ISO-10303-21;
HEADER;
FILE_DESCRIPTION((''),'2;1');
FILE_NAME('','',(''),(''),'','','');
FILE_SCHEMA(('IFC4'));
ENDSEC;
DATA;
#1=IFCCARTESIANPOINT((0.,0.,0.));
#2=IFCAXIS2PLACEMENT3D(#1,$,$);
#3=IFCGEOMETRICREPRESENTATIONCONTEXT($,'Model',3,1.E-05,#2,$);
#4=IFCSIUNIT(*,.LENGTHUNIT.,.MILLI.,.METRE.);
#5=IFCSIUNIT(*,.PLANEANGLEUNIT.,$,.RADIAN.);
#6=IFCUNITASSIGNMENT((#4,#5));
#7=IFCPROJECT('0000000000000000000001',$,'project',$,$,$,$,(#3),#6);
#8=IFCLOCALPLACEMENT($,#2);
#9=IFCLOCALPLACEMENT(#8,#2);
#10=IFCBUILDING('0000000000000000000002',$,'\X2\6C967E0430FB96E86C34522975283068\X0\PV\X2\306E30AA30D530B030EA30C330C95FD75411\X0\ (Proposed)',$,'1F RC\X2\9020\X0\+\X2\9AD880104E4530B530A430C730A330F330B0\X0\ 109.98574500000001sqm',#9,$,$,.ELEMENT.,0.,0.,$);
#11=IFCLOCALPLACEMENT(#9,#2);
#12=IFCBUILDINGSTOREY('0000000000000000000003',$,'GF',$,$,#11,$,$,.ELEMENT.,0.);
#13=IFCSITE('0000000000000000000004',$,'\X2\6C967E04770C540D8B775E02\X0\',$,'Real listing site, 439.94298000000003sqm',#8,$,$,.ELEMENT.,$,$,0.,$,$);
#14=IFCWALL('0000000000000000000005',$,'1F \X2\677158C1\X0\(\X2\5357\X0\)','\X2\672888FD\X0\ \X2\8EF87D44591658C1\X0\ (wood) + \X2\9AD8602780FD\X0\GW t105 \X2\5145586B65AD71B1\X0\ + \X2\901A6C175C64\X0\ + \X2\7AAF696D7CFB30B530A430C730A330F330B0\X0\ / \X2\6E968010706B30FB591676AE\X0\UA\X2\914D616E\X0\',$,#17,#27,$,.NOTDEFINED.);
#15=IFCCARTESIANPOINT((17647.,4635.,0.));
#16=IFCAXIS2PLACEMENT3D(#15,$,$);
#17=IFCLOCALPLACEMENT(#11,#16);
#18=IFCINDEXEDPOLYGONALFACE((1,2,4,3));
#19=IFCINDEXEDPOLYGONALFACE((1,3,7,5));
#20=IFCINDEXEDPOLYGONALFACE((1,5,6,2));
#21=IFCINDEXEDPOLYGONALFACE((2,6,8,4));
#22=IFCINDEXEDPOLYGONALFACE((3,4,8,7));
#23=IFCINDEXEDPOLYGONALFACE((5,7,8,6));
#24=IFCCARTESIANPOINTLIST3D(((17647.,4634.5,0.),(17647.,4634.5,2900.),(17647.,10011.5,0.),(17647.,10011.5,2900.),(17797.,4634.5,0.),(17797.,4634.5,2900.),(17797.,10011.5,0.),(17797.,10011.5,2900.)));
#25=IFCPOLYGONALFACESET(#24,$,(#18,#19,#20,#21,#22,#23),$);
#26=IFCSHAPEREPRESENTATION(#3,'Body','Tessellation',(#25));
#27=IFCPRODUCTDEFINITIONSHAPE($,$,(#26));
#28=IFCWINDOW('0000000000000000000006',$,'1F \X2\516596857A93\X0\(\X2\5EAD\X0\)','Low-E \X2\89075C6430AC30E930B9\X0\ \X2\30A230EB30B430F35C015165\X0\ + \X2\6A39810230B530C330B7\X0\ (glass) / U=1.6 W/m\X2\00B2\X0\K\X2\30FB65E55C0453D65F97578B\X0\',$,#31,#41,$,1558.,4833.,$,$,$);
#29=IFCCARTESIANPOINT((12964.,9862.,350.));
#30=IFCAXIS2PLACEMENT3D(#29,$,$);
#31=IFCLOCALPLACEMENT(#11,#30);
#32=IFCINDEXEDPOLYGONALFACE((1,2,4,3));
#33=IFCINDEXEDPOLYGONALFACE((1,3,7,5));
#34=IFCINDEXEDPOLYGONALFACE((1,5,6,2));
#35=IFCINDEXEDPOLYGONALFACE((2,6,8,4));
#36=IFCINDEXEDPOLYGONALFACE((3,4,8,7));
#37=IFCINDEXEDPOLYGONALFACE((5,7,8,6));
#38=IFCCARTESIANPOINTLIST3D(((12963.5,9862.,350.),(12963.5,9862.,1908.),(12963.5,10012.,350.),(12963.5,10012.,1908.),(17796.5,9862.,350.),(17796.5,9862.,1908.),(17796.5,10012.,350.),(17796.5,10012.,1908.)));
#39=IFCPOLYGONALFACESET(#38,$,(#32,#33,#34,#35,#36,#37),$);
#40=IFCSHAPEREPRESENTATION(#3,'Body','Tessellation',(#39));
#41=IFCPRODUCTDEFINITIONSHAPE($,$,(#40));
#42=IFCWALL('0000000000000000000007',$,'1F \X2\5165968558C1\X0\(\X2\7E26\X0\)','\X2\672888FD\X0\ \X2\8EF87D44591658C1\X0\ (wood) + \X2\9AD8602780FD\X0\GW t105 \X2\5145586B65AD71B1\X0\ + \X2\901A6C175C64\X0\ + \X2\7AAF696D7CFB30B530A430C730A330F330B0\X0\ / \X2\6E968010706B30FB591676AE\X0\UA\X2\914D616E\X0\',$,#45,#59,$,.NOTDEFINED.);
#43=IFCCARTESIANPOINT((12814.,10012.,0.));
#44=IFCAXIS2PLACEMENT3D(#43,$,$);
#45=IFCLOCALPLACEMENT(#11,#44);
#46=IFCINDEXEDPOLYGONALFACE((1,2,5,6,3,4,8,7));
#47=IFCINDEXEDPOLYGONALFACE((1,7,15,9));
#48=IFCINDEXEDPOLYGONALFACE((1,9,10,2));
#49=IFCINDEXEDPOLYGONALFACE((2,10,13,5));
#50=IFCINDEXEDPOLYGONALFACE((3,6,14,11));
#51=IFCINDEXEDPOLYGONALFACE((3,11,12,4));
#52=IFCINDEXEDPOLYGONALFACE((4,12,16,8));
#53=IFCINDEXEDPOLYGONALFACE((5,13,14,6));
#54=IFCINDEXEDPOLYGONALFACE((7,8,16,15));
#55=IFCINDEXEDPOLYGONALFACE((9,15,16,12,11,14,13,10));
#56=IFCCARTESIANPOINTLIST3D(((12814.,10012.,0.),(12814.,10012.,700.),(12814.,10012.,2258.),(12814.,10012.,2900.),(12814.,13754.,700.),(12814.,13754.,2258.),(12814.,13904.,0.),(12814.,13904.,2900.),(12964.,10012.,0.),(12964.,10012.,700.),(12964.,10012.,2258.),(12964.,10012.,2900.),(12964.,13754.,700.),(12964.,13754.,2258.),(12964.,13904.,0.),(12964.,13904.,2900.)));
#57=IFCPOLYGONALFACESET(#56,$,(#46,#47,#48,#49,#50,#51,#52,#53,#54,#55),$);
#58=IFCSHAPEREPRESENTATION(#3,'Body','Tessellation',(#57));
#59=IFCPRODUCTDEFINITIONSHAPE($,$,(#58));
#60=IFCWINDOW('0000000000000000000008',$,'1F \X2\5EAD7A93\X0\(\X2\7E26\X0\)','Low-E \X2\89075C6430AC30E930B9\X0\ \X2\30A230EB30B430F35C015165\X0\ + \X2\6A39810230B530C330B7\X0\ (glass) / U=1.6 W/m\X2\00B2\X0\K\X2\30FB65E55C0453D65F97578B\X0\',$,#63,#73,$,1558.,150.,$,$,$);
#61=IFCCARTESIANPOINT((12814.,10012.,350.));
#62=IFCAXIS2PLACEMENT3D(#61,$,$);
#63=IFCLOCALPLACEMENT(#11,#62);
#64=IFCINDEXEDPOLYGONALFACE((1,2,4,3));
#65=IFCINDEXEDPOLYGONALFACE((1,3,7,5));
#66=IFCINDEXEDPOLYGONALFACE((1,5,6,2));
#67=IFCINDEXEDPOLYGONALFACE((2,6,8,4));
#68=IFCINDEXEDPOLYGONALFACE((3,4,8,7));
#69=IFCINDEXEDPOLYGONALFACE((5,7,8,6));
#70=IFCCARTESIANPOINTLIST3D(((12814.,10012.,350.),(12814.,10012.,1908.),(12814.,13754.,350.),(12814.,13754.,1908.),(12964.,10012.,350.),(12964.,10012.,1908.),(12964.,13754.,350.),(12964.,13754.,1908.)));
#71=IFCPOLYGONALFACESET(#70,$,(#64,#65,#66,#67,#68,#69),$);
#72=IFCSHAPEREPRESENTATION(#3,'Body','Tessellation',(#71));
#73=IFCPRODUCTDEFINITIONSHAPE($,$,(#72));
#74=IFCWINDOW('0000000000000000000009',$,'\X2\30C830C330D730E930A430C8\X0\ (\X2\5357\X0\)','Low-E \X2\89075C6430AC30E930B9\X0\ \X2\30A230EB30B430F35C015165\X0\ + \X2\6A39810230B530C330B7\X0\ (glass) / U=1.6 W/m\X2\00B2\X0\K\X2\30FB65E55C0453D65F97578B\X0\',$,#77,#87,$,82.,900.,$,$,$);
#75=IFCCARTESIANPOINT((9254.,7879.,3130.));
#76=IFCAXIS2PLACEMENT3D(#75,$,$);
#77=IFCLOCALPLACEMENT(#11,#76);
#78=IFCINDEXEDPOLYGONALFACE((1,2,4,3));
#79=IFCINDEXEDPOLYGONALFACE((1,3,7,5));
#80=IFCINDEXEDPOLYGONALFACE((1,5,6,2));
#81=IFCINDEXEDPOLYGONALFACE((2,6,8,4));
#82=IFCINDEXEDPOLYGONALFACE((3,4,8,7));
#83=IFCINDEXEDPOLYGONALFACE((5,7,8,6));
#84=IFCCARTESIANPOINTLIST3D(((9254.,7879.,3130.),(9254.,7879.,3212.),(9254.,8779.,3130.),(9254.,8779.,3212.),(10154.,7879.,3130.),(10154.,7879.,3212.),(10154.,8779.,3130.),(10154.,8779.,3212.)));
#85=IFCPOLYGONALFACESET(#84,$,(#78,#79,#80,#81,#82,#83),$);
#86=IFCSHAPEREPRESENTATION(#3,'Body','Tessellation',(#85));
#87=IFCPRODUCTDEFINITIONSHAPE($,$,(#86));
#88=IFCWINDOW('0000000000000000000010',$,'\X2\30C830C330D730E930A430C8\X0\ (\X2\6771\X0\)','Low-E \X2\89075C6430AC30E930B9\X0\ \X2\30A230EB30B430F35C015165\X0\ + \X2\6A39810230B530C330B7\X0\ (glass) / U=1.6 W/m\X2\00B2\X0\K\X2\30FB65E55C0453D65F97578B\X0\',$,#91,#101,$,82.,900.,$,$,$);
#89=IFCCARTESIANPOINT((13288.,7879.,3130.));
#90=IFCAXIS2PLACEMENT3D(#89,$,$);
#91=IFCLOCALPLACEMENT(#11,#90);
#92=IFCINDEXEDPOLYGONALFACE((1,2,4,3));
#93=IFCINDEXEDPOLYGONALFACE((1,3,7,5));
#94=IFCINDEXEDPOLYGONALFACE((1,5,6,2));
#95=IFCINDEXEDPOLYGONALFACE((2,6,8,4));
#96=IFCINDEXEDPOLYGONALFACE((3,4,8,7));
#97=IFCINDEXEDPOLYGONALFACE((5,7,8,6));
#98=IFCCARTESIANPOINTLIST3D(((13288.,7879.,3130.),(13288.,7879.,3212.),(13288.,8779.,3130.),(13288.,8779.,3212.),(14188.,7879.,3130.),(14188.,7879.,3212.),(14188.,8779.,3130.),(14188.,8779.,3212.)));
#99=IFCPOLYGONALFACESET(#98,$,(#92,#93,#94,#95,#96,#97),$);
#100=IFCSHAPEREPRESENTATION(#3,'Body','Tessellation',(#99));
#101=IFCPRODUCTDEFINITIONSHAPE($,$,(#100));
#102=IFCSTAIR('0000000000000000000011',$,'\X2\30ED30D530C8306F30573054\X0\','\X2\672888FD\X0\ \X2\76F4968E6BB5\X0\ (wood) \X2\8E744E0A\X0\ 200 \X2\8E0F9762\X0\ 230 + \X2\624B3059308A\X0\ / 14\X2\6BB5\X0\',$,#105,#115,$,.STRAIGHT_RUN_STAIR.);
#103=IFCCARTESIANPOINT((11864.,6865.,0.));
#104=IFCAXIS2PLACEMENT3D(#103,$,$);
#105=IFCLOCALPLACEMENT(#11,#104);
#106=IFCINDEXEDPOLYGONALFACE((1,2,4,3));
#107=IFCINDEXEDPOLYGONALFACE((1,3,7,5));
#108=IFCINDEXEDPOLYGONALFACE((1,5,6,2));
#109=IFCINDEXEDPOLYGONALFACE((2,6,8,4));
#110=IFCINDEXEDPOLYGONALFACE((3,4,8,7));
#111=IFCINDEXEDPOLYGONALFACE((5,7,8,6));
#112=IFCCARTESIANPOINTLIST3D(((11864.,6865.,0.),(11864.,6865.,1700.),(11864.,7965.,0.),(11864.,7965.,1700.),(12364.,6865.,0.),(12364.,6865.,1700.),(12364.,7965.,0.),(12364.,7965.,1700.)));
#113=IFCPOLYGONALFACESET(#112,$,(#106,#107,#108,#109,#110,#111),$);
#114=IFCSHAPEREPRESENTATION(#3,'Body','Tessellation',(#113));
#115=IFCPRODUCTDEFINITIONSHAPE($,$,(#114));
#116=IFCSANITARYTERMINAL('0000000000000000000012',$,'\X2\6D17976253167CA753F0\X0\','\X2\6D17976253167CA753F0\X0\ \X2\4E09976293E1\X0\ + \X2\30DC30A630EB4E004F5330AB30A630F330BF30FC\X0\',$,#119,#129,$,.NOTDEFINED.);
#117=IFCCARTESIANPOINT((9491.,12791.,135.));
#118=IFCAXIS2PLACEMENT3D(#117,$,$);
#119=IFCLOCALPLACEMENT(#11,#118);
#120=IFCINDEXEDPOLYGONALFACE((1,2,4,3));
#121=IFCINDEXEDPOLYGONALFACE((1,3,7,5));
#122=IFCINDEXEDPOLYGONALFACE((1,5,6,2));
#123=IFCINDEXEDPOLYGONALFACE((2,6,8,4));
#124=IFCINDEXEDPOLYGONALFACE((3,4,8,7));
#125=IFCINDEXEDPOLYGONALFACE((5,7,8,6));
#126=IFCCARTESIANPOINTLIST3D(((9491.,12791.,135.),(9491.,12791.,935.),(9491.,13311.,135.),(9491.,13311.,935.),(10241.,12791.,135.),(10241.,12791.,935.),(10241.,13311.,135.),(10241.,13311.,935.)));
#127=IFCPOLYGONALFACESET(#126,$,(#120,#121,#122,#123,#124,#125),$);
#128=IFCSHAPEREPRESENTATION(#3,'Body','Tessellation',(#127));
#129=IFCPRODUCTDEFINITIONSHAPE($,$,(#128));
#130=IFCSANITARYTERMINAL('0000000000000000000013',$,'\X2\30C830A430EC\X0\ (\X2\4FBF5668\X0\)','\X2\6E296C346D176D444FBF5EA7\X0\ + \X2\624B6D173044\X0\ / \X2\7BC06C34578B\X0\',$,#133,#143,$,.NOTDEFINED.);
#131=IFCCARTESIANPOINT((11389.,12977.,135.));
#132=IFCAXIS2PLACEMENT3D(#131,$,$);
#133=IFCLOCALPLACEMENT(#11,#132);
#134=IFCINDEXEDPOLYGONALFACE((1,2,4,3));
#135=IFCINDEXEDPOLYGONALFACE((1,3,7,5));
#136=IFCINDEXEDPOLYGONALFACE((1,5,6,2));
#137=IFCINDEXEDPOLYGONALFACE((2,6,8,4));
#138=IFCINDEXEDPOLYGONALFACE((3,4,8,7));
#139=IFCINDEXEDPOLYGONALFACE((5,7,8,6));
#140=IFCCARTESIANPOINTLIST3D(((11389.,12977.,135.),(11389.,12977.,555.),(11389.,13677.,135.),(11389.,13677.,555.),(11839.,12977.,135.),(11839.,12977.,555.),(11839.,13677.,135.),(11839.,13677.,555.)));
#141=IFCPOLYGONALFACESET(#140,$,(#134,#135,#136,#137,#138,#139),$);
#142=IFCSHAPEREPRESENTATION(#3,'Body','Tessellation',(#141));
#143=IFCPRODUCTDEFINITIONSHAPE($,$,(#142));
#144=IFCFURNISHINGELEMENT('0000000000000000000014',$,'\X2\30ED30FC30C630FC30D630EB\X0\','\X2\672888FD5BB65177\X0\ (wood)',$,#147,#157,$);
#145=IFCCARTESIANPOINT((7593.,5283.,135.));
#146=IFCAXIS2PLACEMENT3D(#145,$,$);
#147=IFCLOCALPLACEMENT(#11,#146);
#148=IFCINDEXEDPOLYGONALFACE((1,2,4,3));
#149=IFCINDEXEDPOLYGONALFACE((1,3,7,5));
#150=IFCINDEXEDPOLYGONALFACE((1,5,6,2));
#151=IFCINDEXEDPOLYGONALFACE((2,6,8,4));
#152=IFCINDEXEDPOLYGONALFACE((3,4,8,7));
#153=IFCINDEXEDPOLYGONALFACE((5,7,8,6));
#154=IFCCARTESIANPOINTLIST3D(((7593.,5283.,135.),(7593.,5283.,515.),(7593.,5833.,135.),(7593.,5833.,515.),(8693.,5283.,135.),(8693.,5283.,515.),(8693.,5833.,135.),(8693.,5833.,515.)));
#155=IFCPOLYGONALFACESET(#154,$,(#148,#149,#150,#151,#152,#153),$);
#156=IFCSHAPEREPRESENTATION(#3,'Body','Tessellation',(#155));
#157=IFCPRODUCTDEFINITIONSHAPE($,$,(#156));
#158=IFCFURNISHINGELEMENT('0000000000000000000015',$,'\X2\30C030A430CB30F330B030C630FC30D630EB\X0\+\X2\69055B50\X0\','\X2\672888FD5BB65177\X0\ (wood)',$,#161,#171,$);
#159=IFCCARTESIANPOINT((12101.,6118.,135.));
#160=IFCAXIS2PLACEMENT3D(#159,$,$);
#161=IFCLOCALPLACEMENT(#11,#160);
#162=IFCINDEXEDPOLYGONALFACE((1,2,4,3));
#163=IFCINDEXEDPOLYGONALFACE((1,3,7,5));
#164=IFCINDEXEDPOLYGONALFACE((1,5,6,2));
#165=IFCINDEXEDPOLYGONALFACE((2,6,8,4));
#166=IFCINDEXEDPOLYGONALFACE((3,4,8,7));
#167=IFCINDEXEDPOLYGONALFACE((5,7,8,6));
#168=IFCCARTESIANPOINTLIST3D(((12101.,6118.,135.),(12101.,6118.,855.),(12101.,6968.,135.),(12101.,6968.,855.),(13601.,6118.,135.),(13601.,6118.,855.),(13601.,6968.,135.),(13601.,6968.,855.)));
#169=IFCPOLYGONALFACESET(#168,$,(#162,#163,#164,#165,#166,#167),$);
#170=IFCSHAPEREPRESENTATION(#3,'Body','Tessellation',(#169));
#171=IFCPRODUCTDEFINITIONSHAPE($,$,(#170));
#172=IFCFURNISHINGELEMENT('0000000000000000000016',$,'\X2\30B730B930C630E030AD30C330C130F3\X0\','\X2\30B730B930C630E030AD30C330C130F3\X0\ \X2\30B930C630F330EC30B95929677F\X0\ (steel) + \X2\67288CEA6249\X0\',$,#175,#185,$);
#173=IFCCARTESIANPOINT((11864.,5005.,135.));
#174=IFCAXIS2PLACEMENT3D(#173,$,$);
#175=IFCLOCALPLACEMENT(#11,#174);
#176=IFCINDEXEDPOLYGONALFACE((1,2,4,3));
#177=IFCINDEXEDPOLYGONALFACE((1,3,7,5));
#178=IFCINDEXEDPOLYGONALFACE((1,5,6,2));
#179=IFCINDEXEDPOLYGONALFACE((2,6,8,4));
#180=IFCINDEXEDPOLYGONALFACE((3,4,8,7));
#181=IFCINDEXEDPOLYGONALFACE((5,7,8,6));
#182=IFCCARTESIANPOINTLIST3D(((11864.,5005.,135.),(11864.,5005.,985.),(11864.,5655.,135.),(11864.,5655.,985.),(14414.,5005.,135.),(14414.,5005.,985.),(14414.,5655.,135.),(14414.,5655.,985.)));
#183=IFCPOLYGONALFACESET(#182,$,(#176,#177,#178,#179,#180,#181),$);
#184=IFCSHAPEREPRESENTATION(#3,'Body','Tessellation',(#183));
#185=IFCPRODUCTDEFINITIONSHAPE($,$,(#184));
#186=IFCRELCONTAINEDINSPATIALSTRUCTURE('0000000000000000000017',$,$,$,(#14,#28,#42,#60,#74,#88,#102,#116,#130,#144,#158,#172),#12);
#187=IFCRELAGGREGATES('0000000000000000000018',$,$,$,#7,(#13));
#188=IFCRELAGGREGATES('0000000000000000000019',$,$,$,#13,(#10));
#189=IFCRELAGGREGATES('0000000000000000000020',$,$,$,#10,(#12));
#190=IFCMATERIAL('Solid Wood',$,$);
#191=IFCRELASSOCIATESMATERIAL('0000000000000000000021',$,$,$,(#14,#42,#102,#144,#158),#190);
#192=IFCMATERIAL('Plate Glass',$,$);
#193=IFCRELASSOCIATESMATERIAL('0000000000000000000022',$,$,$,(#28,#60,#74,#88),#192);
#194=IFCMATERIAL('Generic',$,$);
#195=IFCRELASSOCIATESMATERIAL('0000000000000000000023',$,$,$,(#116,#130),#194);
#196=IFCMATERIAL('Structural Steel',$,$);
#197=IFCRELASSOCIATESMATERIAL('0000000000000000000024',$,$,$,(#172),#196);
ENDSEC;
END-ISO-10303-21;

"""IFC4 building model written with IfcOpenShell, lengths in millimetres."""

from ifc_helpers import new_model, si_unit, frame, frame_2d, origin, place, context, project, spatial, rectangle, extrude, material, element, fill, save


model = new_model("IFC4")

# Units and contexts
model_context = context("Model", 3, precision=1e-05, world=origin())
ifc_project = project(units=[si_unit("LENGTHUNIT", "METRE", prefix="MILLI"), si_unit("PLANEANGLEUNIT", "RADIAN")], contexts=[model_context])

# Site, building, storey
site_placement = place(None, origin())
site = spatial("IfcSite", under=ifc_project, at=site_placement, Name="沖縄県名護市", ObjectType="Real listing site, 439.94298000000003sqm", CompositionType="ELEMENT", RefElevation=0.0)
building_placement = place(site_placement, origin())
building = spatial("IfcBuilding", under=site, at=building_placement, Name="沖縄・雨水利用とPVのオフグリッド志向 (Proposed)", ObjectType="1F RC造+高耐久サイディング 109.98574500000001sqm", CompositionType="ELEMENT", ElevationOfRefHeight=0.0, ElevationOfTerrain=0.0)
storey_placement = place(building_placement, origin())
storey = spatial("IfcBuildingStorey", under=building, at=storey_placement, Name="GF", CompositionType="ELEMENT", Elevation=0.0)

# Shared definitions
ifc_material_1 = material(Name="Solid Wood")

# Wall, opening, window
wall_1_placement = place(storey_placement, frame((17647.0, 4635.0, 0.0)))
wall_1 = element("IfcWall", 1, at=wall_1_placement, inside=storey, material=ifc_material_1, Name="1F 東壁(南)", Description="木製 軸組外壁 (wood) + 高性能GW t105 充填断熱 + 通気層 + 窯業系サイディング / 準耐火・外皮UA配慮", PredefinedType="NOTDEFINED", context=model_context, shape_type="SweptSolid", body=[
    extrude(rectangle(XDim=150.0, YDim=5377.0, at=frame_2d((75.0, 2688.0))), frame((17647.0, 4635.0, 0.0)), (0.0, 0.0, 1.0), 2900.0),
])
opening_1_placement = place(storey_placement, frame((12964.0, 9862.0, 350.0)))
opening_1 = element("IfcOpeningElement", 2, at=opening_1_placement, cuts=wall_1, PredefinedType="NOTDEFINED", context=model_context, shape_type="SweptSolid", body=[
    extrude(rectangle(XDim=4833.0, YDim=150.0, at=frame_2d((2416.0, 75.0))), frame((12964.0, 9862.0, 350.0)), (0.0, 0.0, 1.0), 1558.0),
])
ifc_material_2 = material(Name="Plate Glass")
window_1_placement = place(storey_placement, frame((12964.0, 9862.0, 350.0)))
window_1 = element("IfcWindow", 3, at=window_1_placement, inside=storey, material=ifc_material_2, Name="1F 入隅窓(庭)", Description="Low-E 複層ガラス アルゴン封入 + 樹脂サッシ (glass) / U=1.6 W/m²K・日射取得型", OverallHeight=1558.0, OverallWidth=4833.0, context=model_context, shape_type="SweptSolid", body=[
    extrude(rectangle(XDim=4833.0, YDim=150.0, at=frame_2d((2416.0, 75.0))), frame((12964.0, 9862.0, 350.0)), (0.0, 0.0, 1.0), 1558.0),
])
fill(opening_1, window_1)

# Wall, opening, window
wall_2_placement = place(storey_placement, frame((12814.0, 10012.0, 0.0)))
wall_2 = element("IfcWall", 4, at=wall_2_placement, inside=storey, material=ifc_material_1, Name="1F 入隅壁(縦)", Description="木製 軸組外壁 (wood) + 高性能GW t105 充填断熱 + 通気層 + 窯業系サイディング / 準耐火・外皮UA配慮", PredefinedType="NOTDEFINED", context=model_context, shape_type="SweptSolid", body=[
    extrude(rectangle(XDim=150.0, YDim=3892.0, at=frame_2d((75.0, 1946.0))), frame((12814.0, 10012.0, 0.0)), (0.0, 0.0, 1.0), 2900.0),
])
opening_2_placement = place(storey_placement, frame((12814.0, 10012.0, 350.0)))
opening_2 = element("IfcOpeningElement", 5, at=opening_2_placement, cuts=wall_2, PredefinedType="NOTDEFINED", context=model_context, shape_type="SweptSolid", body=[
    extrude(rectangle(XDim=150.0, YDim=3742.0, at=frame_2d((75.0, 1871.0))), frame((12814.0, 10012.0, 350.0)), (0.0, 0.0, 1.0), 1558.0),
])
window_2_placement = place(storey_placement, frame((12814.0, 10012.0, 350.0)))
window_2 = element("IfcWindow", 6, at=window_2_placement, inside=storey, material=ifc_material_2, Name="1F 庭窓(縦)", Description="Low-E 複層ガラス アルゴン封入 + 樹脂サッシ (glass) / U=1.6 W/m²K・日射取得型", OverallHeight=1558.0, OverallWidth=150.0, context=model_context, shape_type="SweptSolid", body=[
    extrude(rectangle(XDim=150.0, YDim=3742.0, at=frame_2d((75.0, 1871.0))), frame((12814.0, 10012.0, 350.0)), (0.0, 0.0, 1.0), 1558.0),
])
fill(opening_2, window_2)

# Windows
window_3_placement = place(storey_placement, frame((9254.0, 7879.0, 3130.0)))
element("IfcWindow", 7, at=window_3_placement, inside=storey, material=ifc_material_2, Name="トップライト (南)", Description="Low-E 複層ガラス アルゴン封入 + 樹脂サッシ (glass) / U=1.6 W/m²K・日射取得型", OverallHeight=82.0, OverallWidth=900.0, context=model_context, shape_type="SweptSolid", body=[
    extrude(rectangle(XDim=900.0, YDim=900.0, at=frame_2d((450.0, 450.0))), frame((9254.0, 7879.0, 3130.0)), (0.0, 0.0, 1.0), 82.0),
])
window_4_placement = place(storey_placement, frame((13288.0, 7879.0, 3130.0)))
element("IfcWindow", 8, at=window_4_placement, inside=storey, material=ifc_material_2, Name="トップライト (東)", Description="Low-E 複層ガラス アルゴン封入 + 樹脂サッシ (glass) / U=1.6 W/m²K・日射取得型", OverallHeight=82.0, OverallWidth=900.0, context=model_context, shape_type="SweptSolid", body=[
    extrude(rectangle(XDim=900.0, YDim=900.0, at=frame_2d((450.0, 450.0))), frame((13288.0, 7879.0, 3130.0)), (0.0, 0.0, 1.0), 82.0),
])

# Stair
stair_placement = place(storey_placement, frame((11864.0, 6865.0, 0.0)))
element("IfcStair", 9, at=stair_placement, inside=storey, material=ifc_material_1, Name="ロフトはしご", Description="木製 直階段 (wood) 蹴上 200 踏面 230 + 手すり / 14段", PredefinedType="STRAIGHT_RUN_STAIR", context=model_context, shape_type="SweptSolid", body=[
    extrude(rectangle(XDim=500.0, YDim=1100.0, at=frame_2d((250.0, 550.0))), frame((11864.0, 6865.0, 0.0)), (0.0, 0.0, 1.0), 1700.0),
])

# Sanitary terminals
ifc_material_3 = material(Name="Generic")
sanitary_terminal_1_placement = place(storey_placement, frame((9491.0, 12791.0, 135.0)))
element("IfcSanitaryTerminal", 10, at=sanitary_terminal_1_placement, inside=storey, material=ifc_material_3, Name="洗面化粧台", Description="洗面化粧台 三面鏡 + ボウル一体カウンター", PredefinedType="NOTDEFINED", context=model_context, shape_type="SweptSolid", body=[
    extrude(rectangle(XDim=750.0, YDim=520.0, at=frame_2d((375.0, 260.0))), frame((9491.0, 12791.0, 135.0)), (0.0, 0.0, 1.0), 800.0),
])
sanitary_terminal_2_placement = place(storey_placement, frame((11389.0, 12977.0, 135.0)))
element("IfcSanitaryTerminal", 11, at=sanitary_terminal_2_placement, inside=storey, material=ifc_material_3, Name="トイレ (便器)", Description="温水洗浄便座 + 手洗い / 節水型", PredefinedType="NOTDEFINED", context=model_context, shape_type="SweptSolid", body=[
    extrude(rectangle(XDim=450.0, YDim=700.0, at=frame_2d((225.0, 350.0))), frame((11389.0, 12977.0, 135.0)), (0.0, 0.0, 1.0), 420.0),
])

# Furnishing elements
furnishing_1_placement = place(storey_placement, frame((7593.0, 5283.0, 135.0)))
element("IfcFurnishingElement", 12, at=furnishing_1_placement, inside=storey, material=ifc_material_1, Name="ローテーブル", Description="木製家具 (wood)", context=model_context, shape_type="SweptSolid", body=[
    extrude(rectangle(XDim=1100.0, YDim=550.0, at=frame_2d((550.0, 275.0))), frame((7593.0, 5283.0, 135.0)), (0.0, 0.0, 1.0), 380.0),
])
furnishing_2_placement = place(storey_placement, frame((12101.0, 6118.0, 135.0)))
element("IfcFurnishingElement", 13, at=furnishing_2_placement, inside=storey, material=ifc_material_1, Name="ダイニングテーブル+椅子", Description="木製家具 (wood)", context=model_context, shape_type="SweptSolid", body=[
    extrude(rectangle(XDim=1500.0, YDim=850.0, at=frame_2d((750.0, 425.0))), frame((12101.0, 6118.0, 135.0)), (0.0, 0.0, 1.0), 720.0),
])
ifc_material_4 = material(Name="Structural Steel")
furnishing_3_placement = place(storey_placement, frame((11864.0, 5005.0, 135.0)))
element("IfcFurnishingElement", 14, at=furnishing_3_placement, inside=storey, material=ifc_material_4, Name="システムキッチン", Description="システムキッチン ステンレス天板 (steel) + 木質扉", context=model_context, shape_type="SweptSolid", body=[
    extrude(rectangle(XDim=2550.0, YDim=650.0, at=frame_2d((1275.0, 325.0))), frame((11864.0, 5005.0, 135.0)), (0.0, 0.0, 1.0), 850.0),
])

save(model, "model.ifc")
